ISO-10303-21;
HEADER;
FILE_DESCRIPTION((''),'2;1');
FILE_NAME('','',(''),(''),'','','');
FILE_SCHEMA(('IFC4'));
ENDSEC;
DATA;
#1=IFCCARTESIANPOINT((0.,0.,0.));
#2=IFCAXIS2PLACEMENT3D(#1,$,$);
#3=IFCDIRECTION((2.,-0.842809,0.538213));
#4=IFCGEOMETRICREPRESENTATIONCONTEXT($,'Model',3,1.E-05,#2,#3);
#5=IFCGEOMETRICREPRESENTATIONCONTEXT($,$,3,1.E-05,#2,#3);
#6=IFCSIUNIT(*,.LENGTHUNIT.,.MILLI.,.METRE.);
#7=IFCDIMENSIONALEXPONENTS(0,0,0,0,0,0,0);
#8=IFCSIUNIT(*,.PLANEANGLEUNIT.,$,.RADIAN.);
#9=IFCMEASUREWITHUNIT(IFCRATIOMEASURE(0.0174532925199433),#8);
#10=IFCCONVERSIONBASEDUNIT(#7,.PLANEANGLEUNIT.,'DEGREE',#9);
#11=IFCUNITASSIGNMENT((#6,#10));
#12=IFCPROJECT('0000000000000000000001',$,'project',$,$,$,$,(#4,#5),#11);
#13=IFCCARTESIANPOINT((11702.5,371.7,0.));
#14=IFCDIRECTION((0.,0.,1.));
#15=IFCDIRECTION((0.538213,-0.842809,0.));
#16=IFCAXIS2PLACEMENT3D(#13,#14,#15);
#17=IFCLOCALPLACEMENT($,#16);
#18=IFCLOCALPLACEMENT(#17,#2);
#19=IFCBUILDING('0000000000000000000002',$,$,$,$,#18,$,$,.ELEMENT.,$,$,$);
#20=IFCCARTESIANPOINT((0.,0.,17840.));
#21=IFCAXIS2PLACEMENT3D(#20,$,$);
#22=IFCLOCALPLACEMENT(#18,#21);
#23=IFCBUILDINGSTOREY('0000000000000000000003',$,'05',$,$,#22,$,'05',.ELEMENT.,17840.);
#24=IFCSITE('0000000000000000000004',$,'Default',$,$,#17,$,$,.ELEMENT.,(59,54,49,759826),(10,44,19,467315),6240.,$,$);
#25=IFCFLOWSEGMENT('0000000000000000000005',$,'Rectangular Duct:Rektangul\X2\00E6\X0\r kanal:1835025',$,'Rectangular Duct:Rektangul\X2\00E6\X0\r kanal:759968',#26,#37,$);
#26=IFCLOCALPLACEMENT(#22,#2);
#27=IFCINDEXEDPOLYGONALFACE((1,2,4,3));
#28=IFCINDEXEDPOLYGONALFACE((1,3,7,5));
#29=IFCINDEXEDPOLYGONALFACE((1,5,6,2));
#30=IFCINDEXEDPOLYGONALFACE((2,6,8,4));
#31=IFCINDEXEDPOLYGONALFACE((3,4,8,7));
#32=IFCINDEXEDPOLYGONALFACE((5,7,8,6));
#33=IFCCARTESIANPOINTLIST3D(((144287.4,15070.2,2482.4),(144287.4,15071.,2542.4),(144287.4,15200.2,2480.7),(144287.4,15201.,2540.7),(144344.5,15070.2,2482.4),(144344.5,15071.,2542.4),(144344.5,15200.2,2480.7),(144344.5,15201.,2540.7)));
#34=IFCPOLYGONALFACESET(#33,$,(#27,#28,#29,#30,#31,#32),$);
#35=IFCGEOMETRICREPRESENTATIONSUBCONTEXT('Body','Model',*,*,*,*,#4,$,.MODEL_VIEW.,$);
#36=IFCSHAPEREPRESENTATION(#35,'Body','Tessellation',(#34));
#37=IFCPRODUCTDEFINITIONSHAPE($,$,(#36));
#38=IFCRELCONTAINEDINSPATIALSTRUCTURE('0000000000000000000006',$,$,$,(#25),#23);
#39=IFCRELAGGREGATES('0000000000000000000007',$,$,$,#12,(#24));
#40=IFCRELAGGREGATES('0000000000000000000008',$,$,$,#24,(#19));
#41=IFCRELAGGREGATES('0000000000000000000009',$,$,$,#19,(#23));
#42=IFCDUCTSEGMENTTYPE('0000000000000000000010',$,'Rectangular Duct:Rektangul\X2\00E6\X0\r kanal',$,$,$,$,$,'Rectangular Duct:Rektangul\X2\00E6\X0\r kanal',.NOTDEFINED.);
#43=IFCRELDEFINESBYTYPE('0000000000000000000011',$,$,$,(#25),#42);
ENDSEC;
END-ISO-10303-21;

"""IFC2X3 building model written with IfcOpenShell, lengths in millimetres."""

from ifc_helpers import new_model, entity, si_unit, converted_unit, direction, frame, frame_2d, origin, place, context, subcontext, project, spatial, rectangle, extrude, type_object, element, save


model = new_model("IFC2X3")

# Units and contexts
model_context = context("Model", 3, precision=1e-05, world=origin(), true_north=direction((2.0, -0.842809, 0.538213)))
context_of_model = context(None, 3, precision=1e-05, world=origin(), true_north=direction((2.0, -0.842809, 0.538213)))
body_context = subcontext(model_context, "Body", "Model", "MODEL_VIEW")
ifc_project = project(units=[si_unit("LENGTHUNIT", "METRE", prefix="MILLI"), converted_unit("PLANEANGLEUNIT", "DEGREE", entity("IfcRatioMeasure", 0.0174532925199433), si_unit("PLANEANGLEUNIT", "RADIAN"), dimensions=[0, 0, 0, 0, 0, 0, 0])], contexts=[model_context, context_of_model])

# Site, building, storey
site_placement = place(None, frame((11702.5, 371.7, 0.0), z_axis=(0.0, 0.0, 1.0), x_axis=(0.538213, -0.842809, 0.0)))
site = spatial("IfcSite", under=ifc_project, at=site_placement, Name="Default", CompositionType="ELEMENT", RefLatitude=(59, 54, 49, 759826), RefLongitude=(10, 44, 19, 467315), RefElevation=6240.0)
building_placement = place(site_placement, origin())
building = spatial("IfcBuilding", under=site, at=building_placement, CompositionType="ELEMENT")
storey_placement = place(building_placement, frame((0.0, 0.0, 17840.0)))
storey = spatial("IfcBuildingStorey", under=building, at=storey_placement, Name="05", LongName="05", CompositionType="ELEMENT", Elevation=17840.0)

# Flow segment
duct_segment_type_1 = type_object("IfcDuctSegmentType", Name="Rectangular Duct:Rektangulær kanal", ElementType="Rectangular Duct:Rektangulær kanal", PredefinedType="NOTDEFINED")
flow_segment_1_placement = place(storey_placement, origin())
element("IfcFlowSegment", 1, at=flow_segment_1_placement, inside=storey, type_object=duct_segment_type_1, Name="Rectangular Duct:Rektangulær kanal:1835025", ObjectType="Rectangular Duct:Rektangulær kanal:759968", context=body_context, shape_type="SweptSolid", body=[
    extrude(rectangle(XDim=60.0, YDim=57.1, at=frame_2d((0.0, 0.0), x_axis=(0.0, 1.0))), frame((144316.0, 15070.6, 2512.4), z_axis=(0.0, 0.999912, -0.013237), x_axis=(1.0, 0.0, 0.0)), (0.0, 0.0, 1.0), 130.0),
])

save(model, "model.ifc")
